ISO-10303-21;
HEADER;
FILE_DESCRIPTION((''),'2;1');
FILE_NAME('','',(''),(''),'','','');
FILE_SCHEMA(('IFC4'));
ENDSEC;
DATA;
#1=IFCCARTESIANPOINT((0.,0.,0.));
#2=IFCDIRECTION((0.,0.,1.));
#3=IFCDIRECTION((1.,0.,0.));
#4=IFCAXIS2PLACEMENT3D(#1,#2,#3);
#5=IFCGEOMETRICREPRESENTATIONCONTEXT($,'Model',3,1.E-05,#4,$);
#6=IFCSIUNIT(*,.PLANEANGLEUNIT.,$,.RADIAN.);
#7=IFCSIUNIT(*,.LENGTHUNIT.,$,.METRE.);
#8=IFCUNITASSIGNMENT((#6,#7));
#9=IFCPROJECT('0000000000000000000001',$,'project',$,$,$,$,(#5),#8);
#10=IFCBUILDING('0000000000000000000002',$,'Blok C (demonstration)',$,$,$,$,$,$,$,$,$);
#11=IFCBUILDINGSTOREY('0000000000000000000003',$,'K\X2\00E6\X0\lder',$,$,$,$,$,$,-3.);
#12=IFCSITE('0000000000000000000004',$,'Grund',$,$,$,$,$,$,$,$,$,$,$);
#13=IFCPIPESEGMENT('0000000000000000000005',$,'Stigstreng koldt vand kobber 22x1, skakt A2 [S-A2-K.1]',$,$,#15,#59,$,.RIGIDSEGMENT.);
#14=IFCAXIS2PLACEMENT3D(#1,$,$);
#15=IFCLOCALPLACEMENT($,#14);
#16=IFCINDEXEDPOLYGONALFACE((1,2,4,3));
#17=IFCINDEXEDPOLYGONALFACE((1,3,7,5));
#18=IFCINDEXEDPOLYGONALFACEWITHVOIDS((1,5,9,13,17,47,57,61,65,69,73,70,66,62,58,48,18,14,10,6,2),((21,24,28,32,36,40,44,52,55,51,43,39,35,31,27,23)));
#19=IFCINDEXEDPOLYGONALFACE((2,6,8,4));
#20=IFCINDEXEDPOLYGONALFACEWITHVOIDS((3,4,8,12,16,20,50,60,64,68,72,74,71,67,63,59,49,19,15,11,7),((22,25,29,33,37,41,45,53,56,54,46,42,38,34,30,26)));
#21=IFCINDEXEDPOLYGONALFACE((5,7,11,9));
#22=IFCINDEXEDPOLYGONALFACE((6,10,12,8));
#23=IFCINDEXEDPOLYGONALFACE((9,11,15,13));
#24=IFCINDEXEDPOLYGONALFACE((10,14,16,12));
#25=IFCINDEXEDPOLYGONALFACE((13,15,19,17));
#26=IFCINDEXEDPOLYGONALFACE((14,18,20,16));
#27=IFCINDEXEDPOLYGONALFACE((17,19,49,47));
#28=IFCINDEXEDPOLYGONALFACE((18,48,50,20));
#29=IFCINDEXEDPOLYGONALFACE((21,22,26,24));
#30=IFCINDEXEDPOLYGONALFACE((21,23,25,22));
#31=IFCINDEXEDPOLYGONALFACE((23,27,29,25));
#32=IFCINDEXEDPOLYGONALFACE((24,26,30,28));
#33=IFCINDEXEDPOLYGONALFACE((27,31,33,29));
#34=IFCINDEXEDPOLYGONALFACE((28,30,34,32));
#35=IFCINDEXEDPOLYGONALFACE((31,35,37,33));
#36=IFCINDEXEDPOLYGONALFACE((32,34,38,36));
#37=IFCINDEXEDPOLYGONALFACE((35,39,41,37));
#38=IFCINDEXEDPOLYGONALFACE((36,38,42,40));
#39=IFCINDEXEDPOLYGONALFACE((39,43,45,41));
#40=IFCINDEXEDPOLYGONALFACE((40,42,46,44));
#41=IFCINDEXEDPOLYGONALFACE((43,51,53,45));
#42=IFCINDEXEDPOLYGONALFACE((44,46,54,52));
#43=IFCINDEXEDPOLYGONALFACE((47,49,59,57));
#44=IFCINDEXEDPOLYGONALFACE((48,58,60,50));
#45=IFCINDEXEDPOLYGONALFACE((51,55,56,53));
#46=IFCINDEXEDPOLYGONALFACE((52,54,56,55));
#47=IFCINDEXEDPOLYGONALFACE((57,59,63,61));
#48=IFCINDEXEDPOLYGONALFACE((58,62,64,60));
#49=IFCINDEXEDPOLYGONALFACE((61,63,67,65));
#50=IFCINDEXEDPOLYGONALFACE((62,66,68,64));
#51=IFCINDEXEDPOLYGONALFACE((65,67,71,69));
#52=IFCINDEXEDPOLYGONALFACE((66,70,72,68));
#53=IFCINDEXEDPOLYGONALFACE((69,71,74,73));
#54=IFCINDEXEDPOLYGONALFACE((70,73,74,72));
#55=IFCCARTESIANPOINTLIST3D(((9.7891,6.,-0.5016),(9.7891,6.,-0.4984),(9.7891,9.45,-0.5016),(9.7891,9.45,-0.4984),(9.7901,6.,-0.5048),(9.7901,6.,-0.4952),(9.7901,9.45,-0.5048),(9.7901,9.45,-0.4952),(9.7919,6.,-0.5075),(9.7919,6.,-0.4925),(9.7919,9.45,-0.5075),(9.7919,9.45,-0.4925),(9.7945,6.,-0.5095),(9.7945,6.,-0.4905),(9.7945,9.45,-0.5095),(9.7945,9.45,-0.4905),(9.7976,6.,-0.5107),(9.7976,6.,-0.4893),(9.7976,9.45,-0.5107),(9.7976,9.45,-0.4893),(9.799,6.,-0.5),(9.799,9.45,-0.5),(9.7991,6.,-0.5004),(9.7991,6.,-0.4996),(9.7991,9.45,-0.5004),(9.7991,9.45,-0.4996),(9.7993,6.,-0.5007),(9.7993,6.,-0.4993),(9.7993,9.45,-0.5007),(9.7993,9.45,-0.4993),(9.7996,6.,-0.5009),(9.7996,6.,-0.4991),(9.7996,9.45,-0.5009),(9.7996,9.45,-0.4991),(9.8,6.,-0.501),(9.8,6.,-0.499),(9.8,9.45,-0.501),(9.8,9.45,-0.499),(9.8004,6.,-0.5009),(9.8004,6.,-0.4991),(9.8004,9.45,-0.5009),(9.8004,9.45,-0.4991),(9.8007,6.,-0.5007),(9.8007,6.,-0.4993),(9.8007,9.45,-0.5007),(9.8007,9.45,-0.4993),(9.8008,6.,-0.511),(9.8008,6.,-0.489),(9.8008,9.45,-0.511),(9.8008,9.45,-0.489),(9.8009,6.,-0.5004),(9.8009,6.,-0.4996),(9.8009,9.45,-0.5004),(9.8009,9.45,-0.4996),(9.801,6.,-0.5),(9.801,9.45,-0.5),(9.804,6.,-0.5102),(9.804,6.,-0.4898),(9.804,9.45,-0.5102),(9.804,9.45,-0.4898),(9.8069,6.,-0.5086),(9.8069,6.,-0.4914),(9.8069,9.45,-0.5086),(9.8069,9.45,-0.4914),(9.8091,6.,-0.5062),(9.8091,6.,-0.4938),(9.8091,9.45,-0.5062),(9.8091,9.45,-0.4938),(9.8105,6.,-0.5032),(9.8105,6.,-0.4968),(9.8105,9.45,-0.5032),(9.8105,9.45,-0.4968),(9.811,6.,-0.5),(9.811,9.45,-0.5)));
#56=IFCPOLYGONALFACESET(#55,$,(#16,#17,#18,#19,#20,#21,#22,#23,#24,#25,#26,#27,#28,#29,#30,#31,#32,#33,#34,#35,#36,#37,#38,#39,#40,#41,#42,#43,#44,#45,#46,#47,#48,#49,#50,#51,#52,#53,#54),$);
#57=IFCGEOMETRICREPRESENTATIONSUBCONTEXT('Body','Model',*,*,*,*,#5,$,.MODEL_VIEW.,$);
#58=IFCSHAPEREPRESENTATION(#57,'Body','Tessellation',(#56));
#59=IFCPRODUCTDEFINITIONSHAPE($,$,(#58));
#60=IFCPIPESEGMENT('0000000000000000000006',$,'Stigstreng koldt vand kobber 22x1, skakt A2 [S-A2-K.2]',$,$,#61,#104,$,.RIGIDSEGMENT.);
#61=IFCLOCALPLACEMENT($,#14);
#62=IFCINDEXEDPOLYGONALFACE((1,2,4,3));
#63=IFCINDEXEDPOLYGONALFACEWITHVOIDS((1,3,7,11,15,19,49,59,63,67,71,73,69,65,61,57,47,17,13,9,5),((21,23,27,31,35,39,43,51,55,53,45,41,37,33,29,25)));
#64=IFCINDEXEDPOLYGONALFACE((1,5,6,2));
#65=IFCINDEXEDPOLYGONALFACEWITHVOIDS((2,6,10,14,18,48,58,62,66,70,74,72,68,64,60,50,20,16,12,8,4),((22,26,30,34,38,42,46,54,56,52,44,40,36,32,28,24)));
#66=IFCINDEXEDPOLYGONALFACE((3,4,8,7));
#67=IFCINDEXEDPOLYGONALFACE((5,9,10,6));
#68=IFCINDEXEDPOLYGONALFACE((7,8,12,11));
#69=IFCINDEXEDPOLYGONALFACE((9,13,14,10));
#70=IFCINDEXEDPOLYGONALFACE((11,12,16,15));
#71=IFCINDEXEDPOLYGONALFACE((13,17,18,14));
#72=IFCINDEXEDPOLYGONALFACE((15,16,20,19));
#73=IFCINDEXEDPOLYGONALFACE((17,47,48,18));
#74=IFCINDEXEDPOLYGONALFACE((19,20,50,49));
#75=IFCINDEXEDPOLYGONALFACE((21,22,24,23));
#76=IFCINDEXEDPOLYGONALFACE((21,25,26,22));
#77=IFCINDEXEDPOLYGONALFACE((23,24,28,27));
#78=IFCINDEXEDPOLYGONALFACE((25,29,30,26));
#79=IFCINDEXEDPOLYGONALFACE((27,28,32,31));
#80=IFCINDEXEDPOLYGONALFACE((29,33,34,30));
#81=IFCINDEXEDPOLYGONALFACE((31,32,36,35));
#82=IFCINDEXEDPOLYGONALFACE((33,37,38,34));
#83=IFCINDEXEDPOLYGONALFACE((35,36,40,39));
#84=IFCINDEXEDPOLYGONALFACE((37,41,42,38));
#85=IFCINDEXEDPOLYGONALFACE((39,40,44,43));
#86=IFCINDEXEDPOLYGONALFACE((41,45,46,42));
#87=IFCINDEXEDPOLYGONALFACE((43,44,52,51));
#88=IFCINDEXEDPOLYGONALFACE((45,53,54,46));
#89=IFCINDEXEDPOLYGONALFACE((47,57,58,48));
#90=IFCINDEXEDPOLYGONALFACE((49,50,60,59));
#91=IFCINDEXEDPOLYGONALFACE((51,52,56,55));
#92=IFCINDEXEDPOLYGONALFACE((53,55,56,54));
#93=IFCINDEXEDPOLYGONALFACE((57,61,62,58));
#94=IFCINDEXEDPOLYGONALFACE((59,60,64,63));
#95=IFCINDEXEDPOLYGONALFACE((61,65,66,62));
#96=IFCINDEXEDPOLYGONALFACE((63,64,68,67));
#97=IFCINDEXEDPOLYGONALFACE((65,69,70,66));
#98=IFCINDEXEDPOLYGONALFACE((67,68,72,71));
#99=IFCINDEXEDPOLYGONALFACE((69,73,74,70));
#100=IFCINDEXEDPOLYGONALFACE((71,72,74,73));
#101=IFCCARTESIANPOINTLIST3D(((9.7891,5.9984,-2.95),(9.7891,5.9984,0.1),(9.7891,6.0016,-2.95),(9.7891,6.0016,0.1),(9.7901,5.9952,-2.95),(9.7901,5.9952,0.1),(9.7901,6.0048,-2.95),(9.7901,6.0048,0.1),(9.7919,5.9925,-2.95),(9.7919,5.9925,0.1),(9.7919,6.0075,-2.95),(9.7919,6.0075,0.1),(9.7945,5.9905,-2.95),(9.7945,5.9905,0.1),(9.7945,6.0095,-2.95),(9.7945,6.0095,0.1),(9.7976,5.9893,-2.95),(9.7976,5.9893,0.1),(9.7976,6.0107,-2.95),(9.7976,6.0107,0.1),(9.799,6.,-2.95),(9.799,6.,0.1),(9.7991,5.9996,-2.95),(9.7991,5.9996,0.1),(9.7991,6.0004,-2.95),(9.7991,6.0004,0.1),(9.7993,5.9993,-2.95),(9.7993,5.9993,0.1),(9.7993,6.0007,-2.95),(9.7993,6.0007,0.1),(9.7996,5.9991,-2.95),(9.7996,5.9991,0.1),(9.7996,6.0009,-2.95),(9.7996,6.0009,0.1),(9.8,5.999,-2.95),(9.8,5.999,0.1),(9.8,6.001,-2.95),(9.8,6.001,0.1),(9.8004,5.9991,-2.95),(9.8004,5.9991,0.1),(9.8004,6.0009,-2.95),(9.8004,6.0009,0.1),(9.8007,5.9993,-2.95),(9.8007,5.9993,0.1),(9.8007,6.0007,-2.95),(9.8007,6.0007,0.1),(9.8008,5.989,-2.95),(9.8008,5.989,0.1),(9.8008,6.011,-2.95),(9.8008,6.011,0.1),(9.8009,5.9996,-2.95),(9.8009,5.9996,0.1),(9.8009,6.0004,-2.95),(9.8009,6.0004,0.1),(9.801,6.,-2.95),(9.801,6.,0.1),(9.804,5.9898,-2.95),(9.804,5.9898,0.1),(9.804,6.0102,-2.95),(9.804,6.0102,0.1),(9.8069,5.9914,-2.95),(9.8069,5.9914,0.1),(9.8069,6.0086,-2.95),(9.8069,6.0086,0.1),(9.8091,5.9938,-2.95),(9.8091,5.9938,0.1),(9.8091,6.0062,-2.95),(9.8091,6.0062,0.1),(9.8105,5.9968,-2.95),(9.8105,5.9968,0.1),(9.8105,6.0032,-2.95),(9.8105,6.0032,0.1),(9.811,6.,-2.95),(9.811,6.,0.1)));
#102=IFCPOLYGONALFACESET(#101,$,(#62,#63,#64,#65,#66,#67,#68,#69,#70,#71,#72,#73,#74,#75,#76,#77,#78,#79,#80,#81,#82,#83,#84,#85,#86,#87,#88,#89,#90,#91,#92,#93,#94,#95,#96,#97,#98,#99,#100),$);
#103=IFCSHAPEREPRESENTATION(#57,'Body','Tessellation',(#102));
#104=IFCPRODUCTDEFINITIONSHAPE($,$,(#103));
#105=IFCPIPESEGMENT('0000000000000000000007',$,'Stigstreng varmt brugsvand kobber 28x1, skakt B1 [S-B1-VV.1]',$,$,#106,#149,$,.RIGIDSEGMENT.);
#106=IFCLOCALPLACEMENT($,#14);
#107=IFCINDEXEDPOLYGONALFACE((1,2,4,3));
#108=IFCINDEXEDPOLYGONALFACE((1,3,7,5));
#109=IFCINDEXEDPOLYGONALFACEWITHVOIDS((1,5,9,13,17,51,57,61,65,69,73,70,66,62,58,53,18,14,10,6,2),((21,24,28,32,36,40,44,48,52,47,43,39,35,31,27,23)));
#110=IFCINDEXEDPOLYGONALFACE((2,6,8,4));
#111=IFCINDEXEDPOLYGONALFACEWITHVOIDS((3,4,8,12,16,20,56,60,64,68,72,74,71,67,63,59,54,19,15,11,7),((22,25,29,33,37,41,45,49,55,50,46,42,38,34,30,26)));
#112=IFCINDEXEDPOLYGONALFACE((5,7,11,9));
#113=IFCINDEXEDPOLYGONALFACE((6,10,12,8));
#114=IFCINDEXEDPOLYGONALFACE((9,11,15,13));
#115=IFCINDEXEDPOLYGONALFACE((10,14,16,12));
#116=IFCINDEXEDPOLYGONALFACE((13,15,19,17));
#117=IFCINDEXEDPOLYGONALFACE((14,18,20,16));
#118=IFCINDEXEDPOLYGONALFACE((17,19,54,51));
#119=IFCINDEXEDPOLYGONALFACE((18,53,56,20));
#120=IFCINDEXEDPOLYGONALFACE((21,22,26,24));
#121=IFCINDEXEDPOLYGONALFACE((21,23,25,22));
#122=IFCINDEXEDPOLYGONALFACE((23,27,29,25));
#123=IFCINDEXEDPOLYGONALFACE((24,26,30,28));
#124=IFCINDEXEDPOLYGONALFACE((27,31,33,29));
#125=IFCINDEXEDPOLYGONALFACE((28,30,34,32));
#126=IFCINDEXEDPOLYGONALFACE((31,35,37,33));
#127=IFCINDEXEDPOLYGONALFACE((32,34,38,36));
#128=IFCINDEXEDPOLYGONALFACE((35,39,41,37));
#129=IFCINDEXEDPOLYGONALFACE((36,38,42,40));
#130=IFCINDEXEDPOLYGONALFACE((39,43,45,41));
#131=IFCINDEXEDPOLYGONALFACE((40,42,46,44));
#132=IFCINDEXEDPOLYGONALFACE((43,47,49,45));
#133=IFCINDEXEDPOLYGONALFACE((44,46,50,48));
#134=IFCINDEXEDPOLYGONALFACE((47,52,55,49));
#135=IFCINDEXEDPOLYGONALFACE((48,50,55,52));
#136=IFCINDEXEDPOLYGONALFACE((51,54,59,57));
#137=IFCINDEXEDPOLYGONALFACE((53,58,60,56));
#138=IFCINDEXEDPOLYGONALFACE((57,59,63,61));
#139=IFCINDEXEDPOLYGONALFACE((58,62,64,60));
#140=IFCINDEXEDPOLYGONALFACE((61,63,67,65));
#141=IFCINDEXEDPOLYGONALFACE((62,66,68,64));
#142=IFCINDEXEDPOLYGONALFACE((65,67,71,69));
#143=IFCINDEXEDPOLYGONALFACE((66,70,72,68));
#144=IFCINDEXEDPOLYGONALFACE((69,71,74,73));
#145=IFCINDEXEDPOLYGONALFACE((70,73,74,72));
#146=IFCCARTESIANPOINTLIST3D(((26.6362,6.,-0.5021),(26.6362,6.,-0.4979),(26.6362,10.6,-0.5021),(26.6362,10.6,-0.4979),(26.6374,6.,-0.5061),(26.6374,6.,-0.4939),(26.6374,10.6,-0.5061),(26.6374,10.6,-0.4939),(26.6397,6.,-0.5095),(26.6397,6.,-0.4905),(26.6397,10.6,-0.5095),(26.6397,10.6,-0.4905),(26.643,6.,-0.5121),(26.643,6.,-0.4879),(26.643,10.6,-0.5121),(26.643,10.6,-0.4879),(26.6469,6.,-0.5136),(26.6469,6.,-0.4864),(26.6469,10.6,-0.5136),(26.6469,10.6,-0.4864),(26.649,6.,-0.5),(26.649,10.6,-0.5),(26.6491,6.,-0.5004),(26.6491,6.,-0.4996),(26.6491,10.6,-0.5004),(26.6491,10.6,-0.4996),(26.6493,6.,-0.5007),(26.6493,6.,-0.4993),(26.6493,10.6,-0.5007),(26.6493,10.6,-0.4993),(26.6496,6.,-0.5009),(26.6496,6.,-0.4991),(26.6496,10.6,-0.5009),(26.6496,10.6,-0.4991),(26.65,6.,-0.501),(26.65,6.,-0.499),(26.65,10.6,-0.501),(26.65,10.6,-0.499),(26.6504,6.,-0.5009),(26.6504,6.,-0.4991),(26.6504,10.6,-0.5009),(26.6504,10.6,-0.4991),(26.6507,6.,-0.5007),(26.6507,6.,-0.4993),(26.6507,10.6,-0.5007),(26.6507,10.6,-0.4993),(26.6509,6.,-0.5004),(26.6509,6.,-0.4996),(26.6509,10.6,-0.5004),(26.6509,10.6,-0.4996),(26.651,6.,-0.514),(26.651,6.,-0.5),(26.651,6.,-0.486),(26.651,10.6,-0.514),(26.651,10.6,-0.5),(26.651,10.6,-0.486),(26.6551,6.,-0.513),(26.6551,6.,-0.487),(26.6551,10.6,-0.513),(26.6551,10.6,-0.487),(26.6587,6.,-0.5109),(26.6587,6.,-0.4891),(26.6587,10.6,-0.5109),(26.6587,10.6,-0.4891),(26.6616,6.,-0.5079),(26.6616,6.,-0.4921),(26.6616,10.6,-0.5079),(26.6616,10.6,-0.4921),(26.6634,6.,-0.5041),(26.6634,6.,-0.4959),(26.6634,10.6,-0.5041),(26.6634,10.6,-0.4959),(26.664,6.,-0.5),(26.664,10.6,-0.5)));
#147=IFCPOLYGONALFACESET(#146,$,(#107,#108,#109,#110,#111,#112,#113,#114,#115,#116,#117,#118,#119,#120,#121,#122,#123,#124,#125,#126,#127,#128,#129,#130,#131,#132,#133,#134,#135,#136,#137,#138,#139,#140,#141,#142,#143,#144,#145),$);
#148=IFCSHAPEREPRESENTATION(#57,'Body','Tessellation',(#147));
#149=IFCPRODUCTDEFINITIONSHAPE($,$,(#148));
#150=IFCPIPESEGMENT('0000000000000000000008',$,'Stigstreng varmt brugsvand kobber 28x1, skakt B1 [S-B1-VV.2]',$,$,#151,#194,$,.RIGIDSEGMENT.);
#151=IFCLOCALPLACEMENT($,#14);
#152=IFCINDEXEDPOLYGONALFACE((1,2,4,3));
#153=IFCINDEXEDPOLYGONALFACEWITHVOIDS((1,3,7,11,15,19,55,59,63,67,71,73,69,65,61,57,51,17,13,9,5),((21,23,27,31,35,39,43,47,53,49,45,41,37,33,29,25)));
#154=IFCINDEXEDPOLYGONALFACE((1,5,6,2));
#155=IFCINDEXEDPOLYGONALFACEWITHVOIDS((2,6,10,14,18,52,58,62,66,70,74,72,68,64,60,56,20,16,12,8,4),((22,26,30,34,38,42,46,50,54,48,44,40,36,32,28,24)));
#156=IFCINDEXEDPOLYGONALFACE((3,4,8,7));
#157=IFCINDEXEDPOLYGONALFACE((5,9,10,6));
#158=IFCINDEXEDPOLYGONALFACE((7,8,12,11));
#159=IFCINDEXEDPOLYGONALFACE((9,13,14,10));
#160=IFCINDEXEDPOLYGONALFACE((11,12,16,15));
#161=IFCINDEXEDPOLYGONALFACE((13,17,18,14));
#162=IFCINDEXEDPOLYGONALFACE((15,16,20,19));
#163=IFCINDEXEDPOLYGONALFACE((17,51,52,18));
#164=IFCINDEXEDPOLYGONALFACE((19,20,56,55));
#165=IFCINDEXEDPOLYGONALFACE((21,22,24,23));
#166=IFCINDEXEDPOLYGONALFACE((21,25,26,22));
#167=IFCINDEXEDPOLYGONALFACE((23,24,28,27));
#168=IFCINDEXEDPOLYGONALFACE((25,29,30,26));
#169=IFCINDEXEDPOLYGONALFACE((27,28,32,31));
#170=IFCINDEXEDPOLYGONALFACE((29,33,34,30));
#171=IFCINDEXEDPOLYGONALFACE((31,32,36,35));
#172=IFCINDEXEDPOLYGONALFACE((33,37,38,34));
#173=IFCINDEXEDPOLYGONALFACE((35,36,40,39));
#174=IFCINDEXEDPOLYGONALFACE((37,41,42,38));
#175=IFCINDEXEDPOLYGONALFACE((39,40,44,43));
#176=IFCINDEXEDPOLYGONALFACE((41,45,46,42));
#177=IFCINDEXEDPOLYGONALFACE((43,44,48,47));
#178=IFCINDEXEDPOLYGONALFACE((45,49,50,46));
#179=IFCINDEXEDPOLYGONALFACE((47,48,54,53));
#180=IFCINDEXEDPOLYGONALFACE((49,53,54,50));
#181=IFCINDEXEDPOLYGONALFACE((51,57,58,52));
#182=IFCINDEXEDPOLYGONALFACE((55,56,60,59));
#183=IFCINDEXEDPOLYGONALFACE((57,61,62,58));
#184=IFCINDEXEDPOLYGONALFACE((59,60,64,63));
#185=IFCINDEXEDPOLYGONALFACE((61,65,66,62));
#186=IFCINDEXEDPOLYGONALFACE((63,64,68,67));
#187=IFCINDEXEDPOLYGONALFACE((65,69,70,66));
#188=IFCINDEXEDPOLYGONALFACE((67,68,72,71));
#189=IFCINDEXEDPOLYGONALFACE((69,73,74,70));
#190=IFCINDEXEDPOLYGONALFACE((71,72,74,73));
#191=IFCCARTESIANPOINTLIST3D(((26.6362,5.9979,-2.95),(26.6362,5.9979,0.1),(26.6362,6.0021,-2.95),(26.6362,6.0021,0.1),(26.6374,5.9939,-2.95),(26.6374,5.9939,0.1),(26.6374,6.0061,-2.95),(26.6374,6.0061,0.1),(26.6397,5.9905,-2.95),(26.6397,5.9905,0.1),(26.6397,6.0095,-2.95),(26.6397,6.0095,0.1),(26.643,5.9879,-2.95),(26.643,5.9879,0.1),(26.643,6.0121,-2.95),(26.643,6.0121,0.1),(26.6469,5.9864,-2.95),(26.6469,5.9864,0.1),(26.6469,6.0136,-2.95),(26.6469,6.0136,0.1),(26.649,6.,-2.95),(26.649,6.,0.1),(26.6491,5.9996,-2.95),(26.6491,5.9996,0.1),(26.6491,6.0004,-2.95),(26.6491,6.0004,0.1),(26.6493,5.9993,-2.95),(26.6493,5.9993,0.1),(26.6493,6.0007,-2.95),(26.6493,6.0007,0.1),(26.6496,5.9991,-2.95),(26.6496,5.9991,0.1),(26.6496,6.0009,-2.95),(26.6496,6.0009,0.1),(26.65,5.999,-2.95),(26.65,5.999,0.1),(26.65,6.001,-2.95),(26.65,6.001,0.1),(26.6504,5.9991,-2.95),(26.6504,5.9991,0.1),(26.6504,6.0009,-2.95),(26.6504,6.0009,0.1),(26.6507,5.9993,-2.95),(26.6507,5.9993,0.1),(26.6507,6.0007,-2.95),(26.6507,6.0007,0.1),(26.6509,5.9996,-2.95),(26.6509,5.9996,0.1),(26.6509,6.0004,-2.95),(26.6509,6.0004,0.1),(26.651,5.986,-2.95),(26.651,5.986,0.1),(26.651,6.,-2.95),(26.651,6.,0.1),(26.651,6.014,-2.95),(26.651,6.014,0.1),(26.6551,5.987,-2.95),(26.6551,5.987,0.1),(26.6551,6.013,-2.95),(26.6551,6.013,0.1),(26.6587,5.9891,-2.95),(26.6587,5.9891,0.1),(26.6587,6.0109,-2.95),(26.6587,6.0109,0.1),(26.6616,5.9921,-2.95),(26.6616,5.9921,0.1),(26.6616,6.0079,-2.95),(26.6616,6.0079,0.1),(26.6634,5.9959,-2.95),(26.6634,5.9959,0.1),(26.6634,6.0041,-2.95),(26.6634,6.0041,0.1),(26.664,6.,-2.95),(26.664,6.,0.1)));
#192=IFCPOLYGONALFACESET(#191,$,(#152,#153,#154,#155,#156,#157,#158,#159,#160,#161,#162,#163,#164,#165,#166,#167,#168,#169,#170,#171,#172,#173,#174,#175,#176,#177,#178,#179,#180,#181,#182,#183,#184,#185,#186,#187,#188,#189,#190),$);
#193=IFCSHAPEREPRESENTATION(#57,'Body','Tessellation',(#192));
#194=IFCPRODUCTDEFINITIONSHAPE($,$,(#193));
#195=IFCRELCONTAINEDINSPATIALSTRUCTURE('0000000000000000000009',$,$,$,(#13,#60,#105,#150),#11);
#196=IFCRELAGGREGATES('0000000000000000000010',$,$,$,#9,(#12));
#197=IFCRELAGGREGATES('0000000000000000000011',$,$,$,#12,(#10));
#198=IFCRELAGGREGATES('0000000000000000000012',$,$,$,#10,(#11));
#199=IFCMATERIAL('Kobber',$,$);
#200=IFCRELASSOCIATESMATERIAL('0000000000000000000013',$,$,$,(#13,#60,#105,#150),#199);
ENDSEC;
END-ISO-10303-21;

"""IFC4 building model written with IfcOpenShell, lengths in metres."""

from ifc_helpers import new_model, si_unit, frame, origin_with_axes, place, context, subcontext, project, spatial, hollow_circle, extrude, material, element, save


model = new_model("IFC4")

# Units and contexts
model_context = context("Model", 3, precision=1e-05, world=origin_with_axes())
body_context = subcontext(model_context, "Body", "Model", "MODEL_VIEW")
ifc_project = project(units=[si_unit("PLANEANGLEUNIT", "RADIAN"), si_unit("LENGTHUNIT", "METRE")], contexts=[model_context])

# Site, building, storey
site = spatial("IfcSite", under=ifc_project, Name="Grund")
building = spatial("IfcBuilding", under=site, Name="Blok C (demonstration)")
storey = spatial("IfcBuildingStorey", under=building, Name="Kælder", Elevation=-3.0)

# Pipe segments
ifc_material_1 = material(Name="Kobber")
pipe_segment_1_placement = place(None, origin_with_axes())
element("IfcPipeSegment", 1, at=pipe_segment_1_placement, inside=storey, material=ifc_material_1, Name="Stigstreng koldt vand kobber 22x1, skakt A2 [S-A2-K.1]", PredefinedType="RIGIDSEGMENT", context=body_context, shape_type="SweptSolid", body=[
    extrude(hollow_circle(Radius=0.011, WallThickness=0.01), frame((9.8, 9.45, -0.5), z_axis=(0.0, -1.0, 0.0), x_axis=(1.0, 0.0, 0.0)), (0.0, 0.0, 1.0), 3.45),
])
pipe_segment_2_placement = place(None, origin_with_axes())
element("IfcPipeSegment", 2, at=pipe_segment_2_placement, inside=storey, material=ifc_material_1, Name="Stigstreng koldt vand kobber 22x1, skakt A2 [S-A2-K.2]", PredefinedType="RIGIDSEGMENT", context=body_context, shape_type="SweptSolid", body=[
    extrude(hollow_circle(Radius=0.011, WallThickness=0.01), frame((9.8, 6.0, -2.95), z_axis=(0.0, 0.0, 1.0), x_axis=(1.0, 0.0, 0.0)), (0.0, 0.0, 1.0), 3.05),
])
pipe_segment_3_placement = place(None, origin_with_axes())
element("IfcPipeSegment", 3, at=pipe_segment_3_placement, inside=storey, material=ifc_material_1, Name="Stigstreng varmt brugsvand kobber 28x1, skakt B1 [S-B1-VV.1]", PredefinedType="RIGIDSEGMENT", context=body_context, shape_type="SweptSolid", body=[
    extrude(hollow_circle(Radius=0.014, WallThickness=0.013), frame((26.65, 10.6, -0.5), z_axis=(0.0, -1.0, 0.0), x_axis=(1.0, 0.0, 0.0)), (0.0, 0.0, 1.0), 4.6),
])
pipe_segment_4_placement = place(None, origin_with_axes())
element("IfcPipeSegment", 4, at=pipe_segment_4_placement, inside=storey, material=ifc_material_1, Name="Stigstreng varmt brugsvand kobber 28x1, skakt B1 [S-B1-VV.2]", PredefinedType="RIGIDSEGMENT", context=body_context, shape_type="SweptSolid", body=[
    extrude(hollow_circle(Radius=0.014, WallThickness=0.013), frame((26.65, 6.0, -2.95), z_axis=(0.0, 0.0, 1.0), x_axis=(1.0, 0.0, 0.0)), (0.0, 0.0, 1.0), 3.05),
])

save(model, "model.ifc")
